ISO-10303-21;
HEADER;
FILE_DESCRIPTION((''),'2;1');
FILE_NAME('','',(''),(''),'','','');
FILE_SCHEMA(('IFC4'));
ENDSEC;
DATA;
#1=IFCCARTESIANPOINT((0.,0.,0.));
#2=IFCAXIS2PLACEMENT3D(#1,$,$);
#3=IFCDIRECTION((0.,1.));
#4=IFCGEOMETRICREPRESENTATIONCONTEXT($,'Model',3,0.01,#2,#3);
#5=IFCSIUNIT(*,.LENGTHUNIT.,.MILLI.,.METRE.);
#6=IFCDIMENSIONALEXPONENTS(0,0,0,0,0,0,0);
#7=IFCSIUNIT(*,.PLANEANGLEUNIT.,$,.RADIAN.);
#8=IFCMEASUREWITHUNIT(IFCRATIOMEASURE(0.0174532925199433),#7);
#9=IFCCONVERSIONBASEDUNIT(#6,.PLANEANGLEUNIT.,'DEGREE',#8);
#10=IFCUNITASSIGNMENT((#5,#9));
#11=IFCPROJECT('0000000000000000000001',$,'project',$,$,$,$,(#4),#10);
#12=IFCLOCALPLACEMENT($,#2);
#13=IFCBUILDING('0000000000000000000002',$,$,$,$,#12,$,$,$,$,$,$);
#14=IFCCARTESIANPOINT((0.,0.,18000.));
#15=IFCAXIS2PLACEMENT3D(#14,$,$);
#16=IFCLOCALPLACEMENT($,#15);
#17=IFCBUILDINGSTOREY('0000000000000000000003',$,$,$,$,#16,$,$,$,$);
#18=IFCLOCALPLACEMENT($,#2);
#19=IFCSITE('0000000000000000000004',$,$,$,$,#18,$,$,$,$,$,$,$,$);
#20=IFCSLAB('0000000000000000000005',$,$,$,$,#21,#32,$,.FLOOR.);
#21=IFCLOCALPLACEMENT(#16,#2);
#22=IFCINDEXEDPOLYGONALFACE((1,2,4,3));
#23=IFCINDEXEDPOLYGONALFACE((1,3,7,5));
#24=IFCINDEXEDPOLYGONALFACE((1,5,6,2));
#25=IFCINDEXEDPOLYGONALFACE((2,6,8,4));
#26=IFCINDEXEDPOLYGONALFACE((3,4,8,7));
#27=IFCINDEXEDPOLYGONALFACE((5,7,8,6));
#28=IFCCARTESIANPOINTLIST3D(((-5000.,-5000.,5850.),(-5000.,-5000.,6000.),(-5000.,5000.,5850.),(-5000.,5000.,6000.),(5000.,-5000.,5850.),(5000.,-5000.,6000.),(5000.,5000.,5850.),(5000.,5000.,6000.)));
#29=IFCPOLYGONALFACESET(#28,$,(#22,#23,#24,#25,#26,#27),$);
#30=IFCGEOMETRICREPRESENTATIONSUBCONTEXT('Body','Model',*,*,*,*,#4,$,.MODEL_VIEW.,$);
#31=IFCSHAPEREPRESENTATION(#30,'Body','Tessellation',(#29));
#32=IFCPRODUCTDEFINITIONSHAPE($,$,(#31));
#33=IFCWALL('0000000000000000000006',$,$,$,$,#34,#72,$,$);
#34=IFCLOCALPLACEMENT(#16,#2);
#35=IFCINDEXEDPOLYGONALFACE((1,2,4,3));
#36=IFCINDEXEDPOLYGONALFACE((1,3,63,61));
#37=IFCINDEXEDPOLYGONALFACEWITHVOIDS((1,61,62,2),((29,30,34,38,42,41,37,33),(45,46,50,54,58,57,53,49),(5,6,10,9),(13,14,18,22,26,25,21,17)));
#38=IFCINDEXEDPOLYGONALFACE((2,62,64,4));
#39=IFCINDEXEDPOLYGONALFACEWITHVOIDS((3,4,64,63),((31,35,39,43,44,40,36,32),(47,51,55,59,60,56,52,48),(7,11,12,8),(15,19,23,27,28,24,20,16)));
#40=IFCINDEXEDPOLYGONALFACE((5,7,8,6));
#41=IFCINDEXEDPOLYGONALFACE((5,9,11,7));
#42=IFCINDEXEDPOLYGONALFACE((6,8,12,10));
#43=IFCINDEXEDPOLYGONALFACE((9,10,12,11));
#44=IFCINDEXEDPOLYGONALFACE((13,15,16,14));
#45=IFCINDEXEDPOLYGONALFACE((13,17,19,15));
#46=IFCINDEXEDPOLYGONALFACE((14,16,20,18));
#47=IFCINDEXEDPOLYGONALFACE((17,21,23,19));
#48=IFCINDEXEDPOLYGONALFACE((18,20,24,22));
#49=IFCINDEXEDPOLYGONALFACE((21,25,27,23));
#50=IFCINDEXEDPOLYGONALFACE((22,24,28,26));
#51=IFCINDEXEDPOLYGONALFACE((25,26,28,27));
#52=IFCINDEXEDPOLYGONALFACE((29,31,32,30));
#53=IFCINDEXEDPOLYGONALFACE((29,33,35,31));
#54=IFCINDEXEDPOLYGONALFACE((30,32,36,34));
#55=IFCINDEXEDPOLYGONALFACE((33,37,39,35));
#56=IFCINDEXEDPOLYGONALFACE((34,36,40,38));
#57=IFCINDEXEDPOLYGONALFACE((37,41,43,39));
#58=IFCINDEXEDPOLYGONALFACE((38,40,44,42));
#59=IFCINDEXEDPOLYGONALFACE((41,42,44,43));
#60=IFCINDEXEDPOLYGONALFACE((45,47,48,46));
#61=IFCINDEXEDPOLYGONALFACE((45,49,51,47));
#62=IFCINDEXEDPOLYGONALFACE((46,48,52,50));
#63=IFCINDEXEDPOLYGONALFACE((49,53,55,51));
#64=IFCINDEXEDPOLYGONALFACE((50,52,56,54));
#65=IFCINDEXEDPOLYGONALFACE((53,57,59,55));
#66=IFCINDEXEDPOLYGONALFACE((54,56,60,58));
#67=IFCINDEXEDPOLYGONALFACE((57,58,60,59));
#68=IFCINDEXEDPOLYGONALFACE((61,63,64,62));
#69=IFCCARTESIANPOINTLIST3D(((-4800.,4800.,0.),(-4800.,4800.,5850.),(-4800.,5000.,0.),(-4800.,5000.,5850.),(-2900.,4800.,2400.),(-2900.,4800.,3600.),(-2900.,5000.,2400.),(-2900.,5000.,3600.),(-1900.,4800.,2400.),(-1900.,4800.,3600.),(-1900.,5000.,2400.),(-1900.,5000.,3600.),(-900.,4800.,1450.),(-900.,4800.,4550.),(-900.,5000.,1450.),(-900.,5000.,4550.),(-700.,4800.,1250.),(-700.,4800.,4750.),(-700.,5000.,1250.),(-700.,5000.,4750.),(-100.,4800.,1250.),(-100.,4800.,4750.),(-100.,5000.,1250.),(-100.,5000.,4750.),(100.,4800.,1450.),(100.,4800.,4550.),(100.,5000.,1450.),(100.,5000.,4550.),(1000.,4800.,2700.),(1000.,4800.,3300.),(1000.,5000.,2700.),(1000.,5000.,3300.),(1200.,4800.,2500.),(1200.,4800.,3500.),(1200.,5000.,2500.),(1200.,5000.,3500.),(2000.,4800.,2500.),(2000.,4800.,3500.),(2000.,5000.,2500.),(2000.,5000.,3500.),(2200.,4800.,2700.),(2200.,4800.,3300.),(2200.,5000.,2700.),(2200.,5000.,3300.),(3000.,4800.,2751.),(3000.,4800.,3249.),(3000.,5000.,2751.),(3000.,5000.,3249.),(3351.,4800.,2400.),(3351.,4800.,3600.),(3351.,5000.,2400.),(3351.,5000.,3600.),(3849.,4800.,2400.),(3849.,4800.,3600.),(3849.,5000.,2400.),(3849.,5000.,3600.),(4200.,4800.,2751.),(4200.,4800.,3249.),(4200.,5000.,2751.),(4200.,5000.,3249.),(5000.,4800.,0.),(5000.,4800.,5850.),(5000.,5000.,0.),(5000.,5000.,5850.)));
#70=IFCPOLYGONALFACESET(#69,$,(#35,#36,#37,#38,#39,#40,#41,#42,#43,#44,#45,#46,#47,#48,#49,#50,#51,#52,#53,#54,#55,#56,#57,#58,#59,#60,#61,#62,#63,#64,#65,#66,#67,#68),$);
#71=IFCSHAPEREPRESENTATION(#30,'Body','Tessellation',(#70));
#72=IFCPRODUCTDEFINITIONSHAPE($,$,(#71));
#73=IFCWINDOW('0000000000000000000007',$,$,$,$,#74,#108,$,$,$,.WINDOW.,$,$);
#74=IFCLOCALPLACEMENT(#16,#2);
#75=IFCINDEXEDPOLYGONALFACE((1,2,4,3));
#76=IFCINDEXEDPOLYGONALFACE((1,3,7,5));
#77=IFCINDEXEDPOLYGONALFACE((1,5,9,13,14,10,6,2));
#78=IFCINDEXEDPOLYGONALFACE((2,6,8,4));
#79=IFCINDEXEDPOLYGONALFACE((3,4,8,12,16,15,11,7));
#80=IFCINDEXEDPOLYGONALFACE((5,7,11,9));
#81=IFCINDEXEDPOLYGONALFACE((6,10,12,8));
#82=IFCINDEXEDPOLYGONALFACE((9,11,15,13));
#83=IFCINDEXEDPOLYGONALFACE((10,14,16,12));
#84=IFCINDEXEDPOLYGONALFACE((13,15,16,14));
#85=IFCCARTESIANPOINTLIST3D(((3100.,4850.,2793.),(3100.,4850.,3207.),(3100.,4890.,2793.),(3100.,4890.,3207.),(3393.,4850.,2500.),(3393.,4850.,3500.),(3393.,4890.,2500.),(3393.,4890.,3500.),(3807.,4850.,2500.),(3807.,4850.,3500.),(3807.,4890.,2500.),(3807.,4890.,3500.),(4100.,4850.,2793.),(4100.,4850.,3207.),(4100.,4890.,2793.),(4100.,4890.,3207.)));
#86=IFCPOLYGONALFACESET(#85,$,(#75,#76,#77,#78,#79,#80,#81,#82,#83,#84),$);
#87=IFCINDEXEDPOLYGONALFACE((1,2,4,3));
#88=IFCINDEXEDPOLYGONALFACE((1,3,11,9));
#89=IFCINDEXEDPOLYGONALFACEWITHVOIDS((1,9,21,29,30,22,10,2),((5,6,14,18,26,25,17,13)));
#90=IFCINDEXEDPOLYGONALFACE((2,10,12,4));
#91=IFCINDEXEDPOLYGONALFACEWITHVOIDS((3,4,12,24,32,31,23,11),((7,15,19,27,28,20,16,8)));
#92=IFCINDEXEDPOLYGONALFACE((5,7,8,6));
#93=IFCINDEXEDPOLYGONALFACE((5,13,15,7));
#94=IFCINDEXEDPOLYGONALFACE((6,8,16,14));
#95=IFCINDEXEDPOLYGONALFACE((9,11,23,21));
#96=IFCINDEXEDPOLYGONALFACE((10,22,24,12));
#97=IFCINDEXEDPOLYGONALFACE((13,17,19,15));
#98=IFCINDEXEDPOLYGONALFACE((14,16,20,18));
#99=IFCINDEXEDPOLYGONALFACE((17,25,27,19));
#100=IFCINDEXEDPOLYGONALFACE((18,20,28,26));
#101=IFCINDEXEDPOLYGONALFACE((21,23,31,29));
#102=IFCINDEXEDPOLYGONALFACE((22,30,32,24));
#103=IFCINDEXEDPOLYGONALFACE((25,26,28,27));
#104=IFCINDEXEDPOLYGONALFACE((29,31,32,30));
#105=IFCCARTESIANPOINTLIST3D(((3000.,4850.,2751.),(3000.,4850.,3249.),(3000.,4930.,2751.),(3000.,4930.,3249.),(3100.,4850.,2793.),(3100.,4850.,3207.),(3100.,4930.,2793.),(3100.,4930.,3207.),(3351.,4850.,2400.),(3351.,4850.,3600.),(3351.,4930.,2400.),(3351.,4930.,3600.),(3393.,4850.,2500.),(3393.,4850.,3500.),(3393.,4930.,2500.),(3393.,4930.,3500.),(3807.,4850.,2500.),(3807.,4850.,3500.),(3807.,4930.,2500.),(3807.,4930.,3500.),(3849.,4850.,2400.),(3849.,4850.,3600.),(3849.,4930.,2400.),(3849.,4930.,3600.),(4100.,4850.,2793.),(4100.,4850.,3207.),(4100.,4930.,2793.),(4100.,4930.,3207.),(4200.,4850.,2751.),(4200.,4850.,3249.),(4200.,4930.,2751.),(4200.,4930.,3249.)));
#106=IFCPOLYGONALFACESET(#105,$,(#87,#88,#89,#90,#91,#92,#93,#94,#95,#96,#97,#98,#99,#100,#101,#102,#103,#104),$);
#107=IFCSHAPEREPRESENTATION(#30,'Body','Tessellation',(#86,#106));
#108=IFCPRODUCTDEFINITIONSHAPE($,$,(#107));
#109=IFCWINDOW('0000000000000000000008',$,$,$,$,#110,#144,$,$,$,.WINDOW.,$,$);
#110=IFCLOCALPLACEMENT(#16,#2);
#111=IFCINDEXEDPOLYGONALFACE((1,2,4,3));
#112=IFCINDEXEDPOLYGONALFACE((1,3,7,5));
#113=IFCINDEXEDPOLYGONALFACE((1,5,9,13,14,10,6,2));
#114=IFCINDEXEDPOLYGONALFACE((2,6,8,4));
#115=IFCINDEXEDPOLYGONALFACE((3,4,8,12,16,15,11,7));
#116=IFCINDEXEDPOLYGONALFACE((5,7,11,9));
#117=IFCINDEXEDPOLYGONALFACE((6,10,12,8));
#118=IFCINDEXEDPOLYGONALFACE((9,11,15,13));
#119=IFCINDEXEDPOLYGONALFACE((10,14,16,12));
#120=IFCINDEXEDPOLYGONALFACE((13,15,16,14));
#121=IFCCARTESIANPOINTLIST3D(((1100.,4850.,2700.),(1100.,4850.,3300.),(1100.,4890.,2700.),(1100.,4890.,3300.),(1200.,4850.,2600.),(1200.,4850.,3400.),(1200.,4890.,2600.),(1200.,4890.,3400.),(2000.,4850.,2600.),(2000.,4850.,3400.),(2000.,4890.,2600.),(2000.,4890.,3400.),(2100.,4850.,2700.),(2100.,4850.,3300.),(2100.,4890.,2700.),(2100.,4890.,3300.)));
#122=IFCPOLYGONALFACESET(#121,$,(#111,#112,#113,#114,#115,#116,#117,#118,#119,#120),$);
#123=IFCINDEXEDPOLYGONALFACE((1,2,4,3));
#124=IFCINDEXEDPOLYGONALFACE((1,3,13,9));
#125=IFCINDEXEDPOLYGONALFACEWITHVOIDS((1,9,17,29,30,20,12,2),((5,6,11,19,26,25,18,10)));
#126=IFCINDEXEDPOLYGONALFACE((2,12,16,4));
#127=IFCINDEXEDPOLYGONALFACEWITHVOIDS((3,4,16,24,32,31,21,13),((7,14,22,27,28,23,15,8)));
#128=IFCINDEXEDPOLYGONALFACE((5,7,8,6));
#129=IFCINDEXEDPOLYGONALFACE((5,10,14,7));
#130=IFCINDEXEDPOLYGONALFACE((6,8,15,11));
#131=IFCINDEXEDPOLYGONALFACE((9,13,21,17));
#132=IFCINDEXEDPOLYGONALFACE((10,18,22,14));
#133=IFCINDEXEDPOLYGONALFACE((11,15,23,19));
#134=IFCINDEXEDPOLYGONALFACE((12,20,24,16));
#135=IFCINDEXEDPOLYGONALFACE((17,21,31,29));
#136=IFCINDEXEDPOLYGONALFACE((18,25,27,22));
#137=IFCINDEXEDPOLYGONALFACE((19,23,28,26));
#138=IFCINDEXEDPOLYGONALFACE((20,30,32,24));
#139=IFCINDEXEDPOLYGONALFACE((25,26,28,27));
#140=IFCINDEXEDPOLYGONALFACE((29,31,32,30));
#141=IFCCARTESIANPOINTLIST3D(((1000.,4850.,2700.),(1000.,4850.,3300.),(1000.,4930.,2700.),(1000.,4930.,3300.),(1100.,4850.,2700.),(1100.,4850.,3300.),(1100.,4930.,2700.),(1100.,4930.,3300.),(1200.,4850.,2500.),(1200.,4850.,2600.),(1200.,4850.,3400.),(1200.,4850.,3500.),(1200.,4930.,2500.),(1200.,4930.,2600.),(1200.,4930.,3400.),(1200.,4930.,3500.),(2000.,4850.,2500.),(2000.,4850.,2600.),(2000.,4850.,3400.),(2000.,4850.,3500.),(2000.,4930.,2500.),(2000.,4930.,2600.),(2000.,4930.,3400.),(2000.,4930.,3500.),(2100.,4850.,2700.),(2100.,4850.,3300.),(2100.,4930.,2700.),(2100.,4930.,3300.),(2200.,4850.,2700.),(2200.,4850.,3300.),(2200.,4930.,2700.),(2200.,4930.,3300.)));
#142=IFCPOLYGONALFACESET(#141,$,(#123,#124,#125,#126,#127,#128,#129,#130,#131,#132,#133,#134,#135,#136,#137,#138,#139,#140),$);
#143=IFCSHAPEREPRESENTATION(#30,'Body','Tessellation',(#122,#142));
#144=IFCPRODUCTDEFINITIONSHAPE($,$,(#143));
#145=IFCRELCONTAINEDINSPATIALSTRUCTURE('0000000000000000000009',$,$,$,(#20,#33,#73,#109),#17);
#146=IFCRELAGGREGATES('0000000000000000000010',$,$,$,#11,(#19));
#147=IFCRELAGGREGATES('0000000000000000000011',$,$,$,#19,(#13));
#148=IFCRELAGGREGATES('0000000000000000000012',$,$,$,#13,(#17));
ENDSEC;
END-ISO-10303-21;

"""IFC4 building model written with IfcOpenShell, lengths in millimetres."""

from ifc_helpers import new_model, entity, si_unit, converted_unit, direction, frame, origin, origin_2d, place, context, subcontext, project, spatial, polyline, rectangle, outline, extrude, element, save


model = new_model("IFC4")

# Units and contexts
model_context = context("Model", 3, precision=0.01, world=origin(), true_north=direction((0.0, 1.0)))
body_context = subcontext(model_context, "Body", "Model", "MODEL_VIEW")
ifc_project = project(units=[si_unit("LENGTHUNIT", "METRE", prefix="MILLI"), converted_unit("PLANEANGLEUNIT", "DEGREE", entity("IfcRatioMeasure", 0.0174532925199433), si_unit("PLANEANGLEUNIT", "RADIAN"), dimensions=[0, 0, 0, 0, 0, 0, 0])], contexts=[model_context])

# Site, building, storey
site_placement = place(None, origin())
site = spatial("IfcSite", under=ifc_project, at=site_placement)
building_placement = place(None, origin())
building = spatial("IfcBuilding", under=site, at=building_placement)
storey_placement = place(None, frame((0.0, 0.0, 18000.0)))
storey = spatial("IfcBuildingStorey", under=building, at=storey_placement)

# Slab
slab_placement = place(storey_placement, frame((0.0, 0.0, 5850.0)))
element("IfcSlab", 1, at=slab_placement, inside=storey, PredefinedType="FLOOR", context=body_context, shape_type="SweptSolid", body=[
    extrude(rectangle(XDim=10000.0, YDim=10000.0, at=origin_2d()), origin(), (0.0, 0.0, 1.0), 150.0),
])

# Wall, openings
wall_1_placement = place(storey_placement, frame((100.0, 4900.0, 0.0), z_axis=(0.0, 0.0, 1.0), x_axis=(-1.0, 0.0, 0.0)))
wall_1 = element("IfcWall", 2, at=wall_1_placement, inside=storey, context=body_context, shape_type="SweptSolid", body=[
    extrude(rectangle(XDim=9800.0, YDim=200.0, at=origin_2d()), origin(), (0.0, 0.0, 1.0), 5850.0),
])
window_1_placement = place(wall_1_placement, frame((-3500.0, 50.0, 3000.0)))
opening_1_placement = place(window_1_placement, frame((0.0, 50.0, 0.0)))
element("IfcOpeningElement", 3, at=opening_1_placement, cuts=wall_1, context=body_context, shape_type="SweptSolid", body=[
    extrude(outline(polyline([(-600.0, -249.0), (-600.0, 249.0), (-249.0, 600.0), (249.0, 600.0), (600.0, 249.0), (600.0, -249.0), (249.0, -600.0), (-249.0, -600.0), (-600.0, -249.0)])), frame((0.0, 0.0, 0.0), z_axis=(0.0, -1.0, 0.0), x_axis=(1.0, 0.0, 0.0)), (0.0, 0.0, 1.0), 200.0),
])
window_2_placement = place(wall_1_placement, frame((-1500.0, 50.0, 3000.0)))
opening_2_placement = place(window_2_placement, frame((0.0, 50.0, 0.0)))
element("IfcOpeningElement", 4, at=opening_2_placement, cuts=wall_1, context=body_context, shape_type="SweptSolid", body=[
    extrude(outline(polyline([(-600.0, -300.0), (-600.0, 300.0), (-400.0, 500.0), (400.0, 500.0), (600.0, 300.0), (600.0, -300.0), (400.0, -500.0), (-400.0, -500.0), (-600.0, -300.0)])), frame((0.0, 0.0, 0.0), z_axis=(0.0, -1.0, 0.0), x_axis=(1.0, 0.0, 0.0)), (0.0, 0.0, 1.0), 200.0),
])
window_3_placement = place(wall_1_placement, frame((500.0, 50.0, 3000.0)))
opening_3_placement = place(window_3_placement, frame((0.0, 50.0, 0.0)))
element("IfcOpeningElement", 5, at=opening_3_placement, cuts=wall_1, context=body_context, shape_type="SweptSolid", body=[
    extrude(outline(polyline([(-500.0, -1550.0), (-500.0, 1550.0), (-300.0, 1750.0), (300.0, 1750.0), (500.0, 1550.0), (500.0, -1550.0), (300.0, -1750.0), (-300.0, -1750.0), (-500.0, -1550.0)])), frame((0.0, 0.0, 0.0), z_axis=(0.0, -1.0, 0.0), x_axis=(1.0, 0.0, 0.0)), (0.0, 0.0, 1.0), 200.0),
])
window_4_placement = place(wall_1_placement, frame((2500.0, 50.0, 3000.0)))
opening_4_placement = place(window_4_placement, frame((0.0, 50.0, 0.0)))
element("IfcOpeningElement", 6, at=opening_4_placement, cuts=wall_1, context=body_context, shape_type="SweptSolid", body=[
    extrude(outline(polyline([(-500.0, -600.0), (-500.0, 600.0), (-500.0, 600.0), (500.0, 600.0), (500.0, 600.0), (500.0, -600.0), (500.0, -600.0), (-500.0, -600.0), (-500.0, -600.0)])), frame((0.0, 0.0, 0.0), z_axis=(0.0, -1.0, 0.0), x_axis=(1.0, 0.0, 0.0)), (0.0, 0.0, 1.0), 200.0),
])

# Windows
cartesian_point_1 = entity("IfcCartesianPoint", [-500.0, -207.0])
shared_polyline_1 = entity("IfcPolyline", [cartesian_point_1, entity("IfcCartesianPoint", [-500.0, 207.0]), entity("IfcCartesianPoint", [-207.0, 500.0]), entity("IfcCartesianPoint", [207.0, 500.0]), entity("IfcCartesianPoint", [500.0, 207.0]), entity("IfcCartesianPoint", [500.0, -207.0]), entity("IfcCartesianPoint", [207.0, -500.0]), entity("IfcCartesianPoint", [-207.0, -500.0]), cartesian_point_1])
cartesian_point_2 = entity("IfcCartesianPoint", [-600.0, -249.0])
element("IfcWindow", 7, at=window_1_placement, inside=storey, PredefinedType="WINDOW", context=body_context, shape_type="SweptSolid", body=[
    entity("IfcExtrudedAreaSolid", entity("IfcArbitraryClosedProfileDef", "AREA", None, shared_polyline_1), entity("IfcAxis2Placement3D", entity("IfcCartesianPoint", [0.0, 0.0, 0.0]), entity("IfcDirection", [0.0, -1.0, 0.0]), entity("IfcDirection", [1.0, 0.0, 0.0])), entity("IfcDirection", [0.0, 0.0, 1.0]), 40.0),
    entity("IfcExtrudedAreaSolid", entity("IfcArbitraryProfileDefWithVoids", "AREA", None, entity("IfcPolyline", [cartesian_point_2, entity("IfcCartesianPoint", [-600.0, 249.0]), entity("IfcCartesianPoint", [-249.0, 600.0]), entity("IfcCartesianPoint", [249.0, 600.0]), entity("IfcCartesianPoint", [600.0, 249.0]), entity("IfcCartesianPoint", [600.0, -249.0]), entity("IfcCartesianPoint", [249.0, -600.0]), entity("IfcCartesianPoint", [-249.0, -600.0]), cartesian_point_2]), [shared_polyline_1]), entity("IfcAxis2Placement3D", entity("IfcCartesianPoint", [0.0, 0.0, 0.0]), entity("IfcDirection", [0.0, -1.0, 0.0]), entity("IfcDirection", [1.0, 0.0, 0.0])), entity("IfcDirection", [0.0, 0.0, 1.0]), 80.0),
])
cartesian_point_3 = entity("IfcCartesianPoint", [-500.0, -300.0])
shared_polyline_2 = entity("IfcPolyline", [cartesian_point_3, entity("IfcCartesianPoint", [-500.0, 300.0]), entity("IfcCartesianPoint", [-400.0, 400.0]), entity("IfcCartesianPoint", [400.0, 400.0]), entity("IfcCartesianPoint", [500.0, 300.0]), entity("IfcCartesianPoint", [500.0, -300.0]), entity("IfcCartesianPoint", [400.0, -400.0]), entity("IfcCartesianPoint", [-400.0, -400.0]), cartesian_point_3])
cartesian_point_4 = entity("IfcCartesianPoint", [-600.0, -300.0])
element("IfcWindow", 8, at=window_2_placement, inside=storey, PredefinedType="WINDOW", context=body_context, shape_type="SweptSolid", body=[
    entity("IfcExtrudedAreaSolid", entity("IfcArbitraryClosedProfileDef", "AREA", None, shared_polyline_2), entity("IfcAxis2Placement3D", entity("IfcCartesianPoint", [0.0, 0.0, 0.0]), entity("IfcDirection", [0.0, -1.0, 0.0]), entity("IfcDirection", [1.0, 0.0, 0.0])), entity("IfcDirection", [0.0, 0.0, 1.0]), 40.0),
    entity("IfcExtrudedAreaSolid", entity("IfcArbitraryProfileDefWithVoids", "AREA", None, entity("IfcPolyline", [cartesian_point_4, entity("IfcCartesianPoint", [-600.0, 300.0]), entity("IfcCartesianPoint", [-400.0, 500.0]), entity("IfcCartesianPoint", [400.0, 500.0]), entity("IfcCartesianPoint", [600.0, 300.0]), entity("IfcCartesianPoint", [600.0, -300.0]), entity("IfcCartesianPoint", [400.0, -500.0]), entity("IfcCartesianPoint", [-400.0, -500.0]), cartesian_point_4]), [shared_polyline_2]), entity("IfcAxis2Placement3D", entity("IfcCartesianPoint", [0.0, 0.0, 0.0]), entity("IfcDirection", [0.0, -1.0, 0.0]), entity("IfcDirection", [1.0, 0.0, 0.0])), entity("IfcDirection", [0.0, 0.0, 1.0]), 80.0),
])

save(model, "model.ifc")
